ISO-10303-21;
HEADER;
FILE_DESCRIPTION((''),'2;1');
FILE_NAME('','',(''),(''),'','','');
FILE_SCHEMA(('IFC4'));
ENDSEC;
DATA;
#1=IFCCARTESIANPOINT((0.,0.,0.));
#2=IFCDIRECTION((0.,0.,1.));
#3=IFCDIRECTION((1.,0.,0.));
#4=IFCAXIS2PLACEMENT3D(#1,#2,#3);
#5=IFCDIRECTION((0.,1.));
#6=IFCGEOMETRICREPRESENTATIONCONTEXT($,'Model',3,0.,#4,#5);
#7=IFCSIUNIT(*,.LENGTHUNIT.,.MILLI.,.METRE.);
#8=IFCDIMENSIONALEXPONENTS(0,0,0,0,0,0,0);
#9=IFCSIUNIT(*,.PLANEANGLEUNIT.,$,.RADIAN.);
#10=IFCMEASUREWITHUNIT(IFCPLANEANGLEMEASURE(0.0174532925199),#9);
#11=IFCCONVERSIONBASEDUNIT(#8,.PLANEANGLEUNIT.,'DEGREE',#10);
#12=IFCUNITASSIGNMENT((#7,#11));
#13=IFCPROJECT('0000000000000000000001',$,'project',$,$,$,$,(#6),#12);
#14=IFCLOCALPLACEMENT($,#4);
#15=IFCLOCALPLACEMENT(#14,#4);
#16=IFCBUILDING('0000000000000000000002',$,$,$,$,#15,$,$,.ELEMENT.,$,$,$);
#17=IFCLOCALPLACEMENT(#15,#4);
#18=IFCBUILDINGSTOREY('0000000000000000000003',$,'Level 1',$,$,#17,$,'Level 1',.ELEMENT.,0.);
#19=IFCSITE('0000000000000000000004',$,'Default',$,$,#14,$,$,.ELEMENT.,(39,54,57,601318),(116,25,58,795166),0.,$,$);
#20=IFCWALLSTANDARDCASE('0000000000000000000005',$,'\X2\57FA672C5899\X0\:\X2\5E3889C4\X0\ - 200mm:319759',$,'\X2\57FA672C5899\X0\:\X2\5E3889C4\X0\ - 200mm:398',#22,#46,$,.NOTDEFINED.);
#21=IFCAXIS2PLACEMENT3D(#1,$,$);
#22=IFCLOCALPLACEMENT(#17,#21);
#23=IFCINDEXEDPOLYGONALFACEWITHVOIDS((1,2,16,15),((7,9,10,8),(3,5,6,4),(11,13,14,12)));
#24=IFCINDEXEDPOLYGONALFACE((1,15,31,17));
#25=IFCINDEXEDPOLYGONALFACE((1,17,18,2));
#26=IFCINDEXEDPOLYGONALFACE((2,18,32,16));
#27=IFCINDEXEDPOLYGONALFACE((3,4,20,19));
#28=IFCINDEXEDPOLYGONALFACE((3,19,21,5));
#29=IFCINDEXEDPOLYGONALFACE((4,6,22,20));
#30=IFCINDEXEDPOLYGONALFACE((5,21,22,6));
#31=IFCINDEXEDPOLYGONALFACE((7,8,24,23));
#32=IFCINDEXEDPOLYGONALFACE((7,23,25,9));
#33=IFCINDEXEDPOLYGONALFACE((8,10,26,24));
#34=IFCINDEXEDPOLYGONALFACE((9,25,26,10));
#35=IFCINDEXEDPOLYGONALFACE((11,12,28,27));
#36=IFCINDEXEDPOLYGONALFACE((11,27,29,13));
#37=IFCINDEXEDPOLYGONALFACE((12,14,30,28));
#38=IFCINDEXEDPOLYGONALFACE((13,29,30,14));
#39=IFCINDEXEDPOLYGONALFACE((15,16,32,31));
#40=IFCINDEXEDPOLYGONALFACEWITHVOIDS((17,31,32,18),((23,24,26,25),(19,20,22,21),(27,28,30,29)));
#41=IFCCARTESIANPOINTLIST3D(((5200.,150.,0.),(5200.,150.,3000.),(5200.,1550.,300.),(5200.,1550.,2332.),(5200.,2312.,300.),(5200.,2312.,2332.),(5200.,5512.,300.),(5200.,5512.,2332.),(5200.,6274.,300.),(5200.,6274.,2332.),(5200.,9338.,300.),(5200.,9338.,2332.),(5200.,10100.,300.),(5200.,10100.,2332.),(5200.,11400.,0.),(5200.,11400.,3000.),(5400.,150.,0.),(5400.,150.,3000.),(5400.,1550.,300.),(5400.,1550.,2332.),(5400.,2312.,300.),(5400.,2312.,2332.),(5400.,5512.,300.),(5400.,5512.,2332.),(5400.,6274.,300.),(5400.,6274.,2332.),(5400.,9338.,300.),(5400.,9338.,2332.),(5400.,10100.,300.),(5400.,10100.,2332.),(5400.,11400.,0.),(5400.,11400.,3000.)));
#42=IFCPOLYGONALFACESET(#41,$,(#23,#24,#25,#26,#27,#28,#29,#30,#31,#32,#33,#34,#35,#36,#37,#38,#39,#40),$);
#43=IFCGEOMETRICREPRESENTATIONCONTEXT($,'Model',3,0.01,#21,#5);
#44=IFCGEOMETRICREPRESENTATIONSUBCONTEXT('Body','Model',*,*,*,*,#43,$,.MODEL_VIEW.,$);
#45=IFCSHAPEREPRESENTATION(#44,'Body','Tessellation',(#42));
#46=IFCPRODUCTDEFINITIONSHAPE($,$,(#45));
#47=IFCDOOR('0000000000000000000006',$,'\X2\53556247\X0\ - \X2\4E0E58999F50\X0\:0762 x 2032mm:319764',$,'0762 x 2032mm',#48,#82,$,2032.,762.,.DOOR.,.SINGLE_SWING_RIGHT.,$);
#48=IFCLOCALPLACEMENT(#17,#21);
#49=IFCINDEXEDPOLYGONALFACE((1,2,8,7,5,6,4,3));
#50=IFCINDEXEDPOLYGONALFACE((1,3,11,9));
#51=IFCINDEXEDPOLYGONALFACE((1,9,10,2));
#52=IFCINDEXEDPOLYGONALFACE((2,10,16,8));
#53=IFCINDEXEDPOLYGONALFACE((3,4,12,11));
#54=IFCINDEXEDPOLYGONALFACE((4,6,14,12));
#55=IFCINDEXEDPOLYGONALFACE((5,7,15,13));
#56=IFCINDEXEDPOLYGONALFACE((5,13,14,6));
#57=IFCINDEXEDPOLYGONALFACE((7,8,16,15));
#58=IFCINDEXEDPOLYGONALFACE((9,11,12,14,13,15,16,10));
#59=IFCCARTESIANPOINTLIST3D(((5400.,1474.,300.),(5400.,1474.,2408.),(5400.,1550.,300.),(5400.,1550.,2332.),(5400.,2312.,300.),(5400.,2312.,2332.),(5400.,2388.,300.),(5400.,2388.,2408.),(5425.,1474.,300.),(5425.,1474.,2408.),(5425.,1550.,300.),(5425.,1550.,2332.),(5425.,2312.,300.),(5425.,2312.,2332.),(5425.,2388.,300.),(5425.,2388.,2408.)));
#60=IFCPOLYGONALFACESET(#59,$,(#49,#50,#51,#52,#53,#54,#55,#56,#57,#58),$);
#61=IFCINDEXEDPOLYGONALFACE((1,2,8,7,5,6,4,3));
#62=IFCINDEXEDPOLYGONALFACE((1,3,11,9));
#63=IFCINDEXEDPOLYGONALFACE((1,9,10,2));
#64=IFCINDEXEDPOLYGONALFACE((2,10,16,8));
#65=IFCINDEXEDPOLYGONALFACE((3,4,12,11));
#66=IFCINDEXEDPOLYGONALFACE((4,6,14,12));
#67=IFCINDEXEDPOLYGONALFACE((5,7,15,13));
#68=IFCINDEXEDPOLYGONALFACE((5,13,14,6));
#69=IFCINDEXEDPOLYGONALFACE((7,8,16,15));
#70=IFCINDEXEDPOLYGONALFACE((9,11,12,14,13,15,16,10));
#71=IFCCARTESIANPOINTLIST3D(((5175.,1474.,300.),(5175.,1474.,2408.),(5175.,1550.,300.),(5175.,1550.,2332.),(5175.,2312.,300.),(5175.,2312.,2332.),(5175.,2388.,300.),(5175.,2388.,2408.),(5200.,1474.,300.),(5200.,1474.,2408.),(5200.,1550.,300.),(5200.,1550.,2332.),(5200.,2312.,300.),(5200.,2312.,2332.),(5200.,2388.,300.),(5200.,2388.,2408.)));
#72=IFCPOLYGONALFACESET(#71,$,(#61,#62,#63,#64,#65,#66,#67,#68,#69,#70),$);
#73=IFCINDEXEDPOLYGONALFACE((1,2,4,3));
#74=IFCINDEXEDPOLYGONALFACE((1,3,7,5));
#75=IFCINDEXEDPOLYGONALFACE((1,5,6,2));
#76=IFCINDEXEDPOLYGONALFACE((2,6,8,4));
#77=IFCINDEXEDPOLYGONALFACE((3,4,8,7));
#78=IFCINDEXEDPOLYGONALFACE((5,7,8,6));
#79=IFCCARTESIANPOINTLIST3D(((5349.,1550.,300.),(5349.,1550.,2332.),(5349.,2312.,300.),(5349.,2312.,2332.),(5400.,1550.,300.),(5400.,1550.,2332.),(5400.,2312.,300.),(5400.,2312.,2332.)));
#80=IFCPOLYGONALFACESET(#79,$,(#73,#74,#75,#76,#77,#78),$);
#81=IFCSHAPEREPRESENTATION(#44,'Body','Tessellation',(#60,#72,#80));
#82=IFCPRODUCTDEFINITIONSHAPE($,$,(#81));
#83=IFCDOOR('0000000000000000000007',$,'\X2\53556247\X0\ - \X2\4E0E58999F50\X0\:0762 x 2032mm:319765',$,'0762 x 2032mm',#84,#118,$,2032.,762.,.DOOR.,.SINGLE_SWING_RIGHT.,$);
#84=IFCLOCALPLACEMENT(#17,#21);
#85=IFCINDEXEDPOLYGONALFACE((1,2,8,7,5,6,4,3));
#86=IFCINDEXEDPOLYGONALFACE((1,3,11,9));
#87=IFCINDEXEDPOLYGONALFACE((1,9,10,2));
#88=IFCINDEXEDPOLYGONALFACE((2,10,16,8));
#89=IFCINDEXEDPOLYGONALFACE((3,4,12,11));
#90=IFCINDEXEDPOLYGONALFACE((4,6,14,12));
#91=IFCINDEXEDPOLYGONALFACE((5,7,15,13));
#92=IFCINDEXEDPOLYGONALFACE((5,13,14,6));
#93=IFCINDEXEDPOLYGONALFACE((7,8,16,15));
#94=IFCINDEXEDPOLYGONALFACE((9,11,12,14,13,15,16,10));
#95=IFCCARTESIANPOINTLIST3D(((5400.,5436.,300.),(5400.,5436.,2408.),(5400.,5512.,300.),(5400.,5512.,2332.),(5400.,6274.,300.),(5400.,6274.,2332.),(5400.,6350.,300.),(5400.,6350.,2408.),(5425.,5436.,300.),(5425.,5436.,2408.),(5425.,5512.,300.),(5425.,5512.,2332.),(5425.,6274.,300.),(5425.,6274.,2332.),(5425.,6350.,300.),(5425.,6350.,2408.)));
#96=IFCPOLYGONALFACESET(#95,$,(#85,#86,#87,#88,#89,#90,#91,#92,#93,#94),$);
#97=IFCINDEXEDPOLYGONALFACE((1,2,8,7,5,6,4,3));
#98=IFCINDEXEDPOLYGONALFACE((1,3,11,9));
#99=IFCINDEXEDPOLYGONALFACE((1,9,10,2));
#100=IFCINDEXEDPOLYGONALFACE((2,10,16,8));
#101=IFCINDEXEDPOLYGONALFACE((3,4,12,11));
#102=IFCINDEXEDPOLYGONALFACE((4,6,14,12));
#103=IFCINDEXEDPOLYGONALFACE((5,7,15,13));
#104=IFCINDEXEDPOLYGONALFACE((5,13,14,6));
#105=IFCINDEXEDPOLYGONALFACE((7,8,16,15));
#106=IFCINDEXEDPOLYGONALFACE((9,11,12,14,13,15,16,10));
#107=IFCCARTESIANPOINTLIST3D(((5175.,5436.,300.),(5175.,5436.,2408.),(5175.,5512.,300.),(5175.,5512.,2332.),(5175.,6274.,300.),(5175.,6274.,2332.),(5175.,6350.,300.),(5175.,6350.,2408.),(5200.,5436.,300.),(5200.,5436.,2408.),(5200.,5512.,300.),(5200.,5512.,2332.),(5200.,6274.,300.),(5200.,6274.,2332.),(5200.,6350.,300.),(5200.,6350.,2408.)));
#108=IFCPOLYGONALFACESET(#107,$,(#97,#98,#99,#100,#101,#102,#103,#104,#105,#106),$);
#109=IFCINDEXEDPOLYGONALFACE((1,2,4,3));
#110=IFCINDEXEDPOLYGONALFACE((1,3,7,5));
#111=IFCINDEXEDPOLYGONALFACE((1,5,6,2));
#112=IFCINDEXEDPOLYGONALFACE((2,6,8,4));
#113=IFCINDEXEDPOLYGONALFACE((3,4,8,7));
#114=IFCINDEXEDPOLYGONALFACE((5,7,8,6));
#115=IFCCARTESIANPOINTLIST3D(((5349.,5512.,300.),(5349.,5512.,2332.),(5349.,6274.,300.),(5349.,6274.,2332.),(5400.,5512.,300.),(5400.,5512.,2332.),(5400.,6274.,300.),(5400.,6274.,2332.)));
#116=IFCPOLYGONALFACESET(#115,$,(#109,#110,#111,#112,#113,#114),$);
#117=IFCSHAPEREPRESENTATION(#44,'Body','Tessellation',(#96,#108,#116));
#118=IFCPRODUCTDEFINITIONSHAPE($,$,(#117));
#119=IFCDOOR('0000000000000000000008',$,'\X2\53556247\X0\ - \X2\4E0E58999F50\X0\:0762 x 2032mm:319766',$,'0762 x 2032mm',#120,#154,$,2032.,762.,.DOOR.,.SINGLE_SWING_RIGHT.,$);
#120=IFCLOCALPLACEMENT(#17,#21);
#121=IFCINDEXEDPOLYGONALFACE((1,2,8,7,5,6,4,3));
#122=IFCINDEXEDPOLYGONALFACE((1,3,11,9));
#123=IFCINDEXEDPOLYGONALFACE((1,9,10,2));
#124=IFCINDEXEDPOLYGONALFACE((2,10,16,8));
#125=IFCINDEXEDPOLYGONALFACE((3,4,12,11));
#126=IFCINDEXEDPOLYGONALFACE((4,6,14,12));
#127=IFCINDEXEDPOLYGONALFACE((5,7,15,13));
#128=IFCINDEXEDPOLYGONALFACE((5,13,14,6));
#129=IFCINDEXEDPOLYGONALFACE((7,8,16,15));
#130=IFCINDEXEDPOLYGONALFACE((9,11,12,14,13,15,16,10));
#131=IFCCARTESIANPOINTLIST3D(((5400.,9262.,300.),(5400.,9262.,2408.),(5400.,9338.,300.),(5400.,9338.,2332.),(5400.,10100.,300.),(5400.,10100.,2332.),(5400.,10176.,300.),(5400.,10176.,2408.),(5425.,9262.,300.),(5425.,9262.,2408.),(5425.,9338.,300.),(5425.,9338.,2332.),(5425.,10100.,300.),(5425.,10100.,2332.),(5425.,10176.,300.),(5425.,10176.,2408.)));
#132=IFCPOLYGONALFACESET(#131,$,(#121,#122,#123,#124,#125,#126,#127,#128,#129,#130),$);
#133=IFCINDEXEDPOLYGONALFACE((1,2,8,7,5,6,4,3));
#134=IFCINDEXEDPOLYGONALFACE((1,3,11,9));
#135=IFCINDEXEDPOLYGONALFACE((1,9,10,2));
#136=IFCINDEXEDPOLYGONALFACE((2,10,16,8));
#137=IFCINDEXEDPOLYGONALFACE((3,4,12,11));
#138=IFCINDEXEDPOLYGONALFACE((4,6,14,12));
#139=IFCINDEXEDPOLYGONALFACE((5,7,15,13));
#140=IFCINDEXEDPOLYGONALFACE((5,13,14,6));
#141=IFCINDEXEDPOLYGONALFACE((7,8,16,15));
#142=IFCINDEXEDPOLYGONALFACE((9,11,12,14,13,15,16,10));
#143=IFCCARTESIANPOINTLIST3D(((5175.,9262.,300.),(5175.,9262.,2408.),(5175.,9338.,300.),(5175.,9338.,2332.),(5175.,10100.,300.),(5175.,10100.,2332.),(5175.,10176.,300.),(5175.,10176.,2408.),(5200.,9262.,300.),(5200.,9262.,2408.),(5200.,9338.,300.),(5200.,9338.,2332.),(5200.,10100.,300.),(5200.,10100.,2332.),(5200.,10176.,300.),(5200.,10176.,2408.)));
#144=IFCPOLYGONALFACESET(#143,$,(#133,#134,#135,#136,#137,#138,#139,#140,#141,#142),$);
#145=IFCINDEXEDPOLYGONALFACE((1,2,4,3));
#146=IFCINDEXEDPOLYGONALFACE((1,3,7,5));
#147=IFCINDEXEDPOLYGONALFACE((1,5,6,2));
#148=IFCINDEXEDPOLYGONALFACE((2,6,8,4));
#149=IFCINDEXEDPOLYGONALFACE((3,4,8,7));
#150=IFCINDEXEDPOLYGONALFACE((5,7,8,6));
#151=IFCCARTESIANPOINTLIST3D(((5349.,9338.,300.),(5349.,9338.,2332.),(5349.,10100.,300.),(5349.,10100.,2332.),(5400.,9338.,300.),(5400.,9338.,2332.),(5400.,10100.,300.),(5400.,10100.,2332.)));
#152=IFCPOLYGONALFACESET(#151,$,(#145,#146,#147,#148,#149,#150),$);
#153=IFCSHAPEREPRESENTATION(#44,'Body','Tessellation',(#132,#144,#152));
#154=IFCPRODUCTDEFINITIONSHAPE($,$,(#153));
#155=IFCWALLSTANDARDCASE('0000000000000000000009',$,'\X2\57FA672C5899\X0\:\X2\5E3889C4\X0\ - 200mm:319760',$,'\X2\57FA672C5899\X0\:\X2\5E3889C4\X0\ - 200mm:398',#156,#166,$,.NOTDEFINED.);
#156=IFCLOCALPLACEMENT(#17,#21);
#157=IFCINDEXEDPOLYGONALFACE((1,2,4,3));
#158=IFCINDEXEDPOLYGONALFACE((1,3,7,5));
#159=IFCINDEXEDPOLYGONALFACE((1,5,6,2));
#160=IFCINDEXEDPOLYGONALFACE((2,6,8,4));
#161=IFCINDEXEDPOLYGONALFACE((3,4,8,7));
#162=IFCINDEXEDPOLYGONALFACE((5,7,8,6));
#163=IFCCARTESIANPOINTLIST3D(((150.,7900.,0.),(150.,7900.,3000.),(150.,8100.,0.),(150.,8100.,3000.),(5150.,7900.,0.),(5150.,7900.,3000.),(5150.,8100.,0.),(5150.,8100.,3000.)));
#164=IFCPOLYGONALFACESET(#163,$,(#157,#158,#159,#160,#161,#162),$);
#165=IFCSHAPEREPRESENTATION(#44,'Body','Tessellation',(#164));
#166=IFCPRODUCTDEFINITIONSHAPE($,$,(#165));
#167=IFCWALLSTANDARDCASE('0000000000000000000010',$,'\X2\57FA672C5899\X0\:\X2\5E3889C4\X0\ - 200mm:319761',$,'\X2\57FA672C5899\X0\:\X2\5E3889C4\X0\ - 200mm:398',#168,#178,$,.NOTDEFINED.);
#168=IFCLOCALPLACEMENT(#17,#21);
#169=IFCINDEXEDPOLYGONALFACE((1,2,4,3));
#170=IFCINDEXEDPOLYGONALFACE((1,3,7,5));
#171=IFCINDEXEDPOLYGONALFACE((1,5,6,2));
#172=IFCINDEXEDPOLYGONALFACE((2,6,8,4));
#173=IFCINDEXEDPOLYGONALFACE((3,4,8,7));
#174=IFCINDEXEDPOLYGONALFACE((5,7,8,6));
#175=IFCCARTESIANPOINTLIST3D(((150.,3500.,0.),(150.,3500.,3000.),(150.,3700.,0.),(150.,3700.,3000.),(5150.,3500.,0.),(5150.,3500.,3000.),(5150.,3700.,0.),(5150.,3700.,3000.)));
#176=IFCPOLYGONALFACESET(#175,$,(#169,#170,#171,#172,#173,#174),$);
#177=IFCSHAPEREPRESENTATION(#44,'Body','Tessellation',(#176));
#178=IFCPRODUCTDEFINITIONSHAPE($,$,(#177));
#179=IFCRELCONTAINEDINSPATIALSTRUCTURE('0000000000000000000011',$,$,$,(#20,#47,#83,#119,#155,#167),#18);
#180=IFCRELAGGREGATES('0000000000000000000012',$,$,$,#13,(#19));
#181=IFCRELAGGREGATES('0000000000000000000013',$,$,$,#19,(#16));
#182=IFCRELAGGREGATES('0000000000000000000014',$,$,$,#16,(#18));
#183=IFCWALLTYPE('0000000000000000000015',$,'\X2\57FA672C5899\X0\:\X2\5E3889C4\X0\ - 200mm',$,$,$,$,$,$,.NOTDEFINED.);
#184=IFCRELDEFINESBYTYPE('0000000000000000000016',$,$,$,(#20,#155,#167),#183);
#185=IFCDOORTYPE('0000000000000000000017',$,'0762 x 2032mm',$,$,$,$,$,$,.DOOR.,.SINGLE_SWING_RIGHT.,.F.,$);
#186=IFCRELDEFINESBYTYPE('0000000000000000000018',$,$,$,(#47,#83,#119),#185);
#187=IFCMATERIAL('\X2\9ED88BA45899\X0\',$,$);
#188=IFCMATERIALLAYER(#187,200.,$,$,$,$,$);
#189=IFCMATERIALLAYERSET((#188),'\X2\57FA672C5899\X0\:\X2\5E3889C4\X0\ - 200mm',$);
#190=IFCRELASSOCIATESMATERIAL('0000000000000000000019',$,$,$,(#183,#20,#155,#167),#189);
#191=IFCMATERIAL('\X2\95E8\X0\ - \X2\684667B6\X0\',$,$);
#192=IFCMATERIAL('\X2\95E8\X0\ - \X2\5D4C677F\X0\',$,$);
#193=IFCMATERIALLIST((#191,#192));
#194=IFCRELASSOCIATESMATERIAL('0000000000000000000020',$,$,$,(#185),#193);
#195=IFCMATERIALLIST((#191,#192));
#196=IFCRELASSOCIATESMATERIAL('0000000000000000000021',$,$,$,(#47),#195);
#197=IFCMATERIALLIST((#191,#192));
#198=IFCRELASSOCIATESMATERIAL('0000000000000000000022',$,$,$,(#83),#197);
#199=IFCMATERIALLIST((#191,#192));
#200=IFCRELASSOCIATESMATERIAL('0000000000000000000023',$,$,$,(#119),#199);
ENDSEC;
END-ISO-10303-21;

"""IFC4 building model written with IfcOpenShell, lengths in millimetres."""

from ifc_helpers import new_model, entity, si_unit, converted_unit, direction, frame, frame_2d, origin, origin_with_axes, origin_2d_with_axis, place, context, subcontext, project, spatial, polyline, rectangle, outline, extrude, source, transform, mapped, material, material_list, layer, layer_set, layer_usage, type_object, type_shapes, element, fill, save


model = new_model("IFC4")

# Units and contexts
model_context_1 = context("Model", 3, precision=0.0, world=origin_with_axes(), true_north=direction((0.0, 1.0)))
model_context_2 = context("Model", 3, precision=0.01, world=origin(), true_north=direction((0.0, 1.0)))
body_context_1 = subcontext(model_context_2, "Body", "Model", "MODEL_VIEW")
ifc_project = project(units=[si_unit("LENGTHUNIT", "METRE", prefix="MILLI"), converted_unit("PLANEANGLEUNIT", "DEGREE", entity("IfcPlaneAngleMeasure", 0.0174532925199), si_unit("PLANEANGLEUNIT", "RADIAN"), dimensions=[0, 0, 0, 0, 0, 0, 0])], contexts=[model_context_1])

# Site, building, storey
site_placement = place(None, origin_with_axes())
site = spatial("IfcSite", under=ifc_project, at=site_placement, Name="Default", CompositionType="ELEMENT", RefLatitude=(39, 54, 57, 601318), RefLongitude=(116, 25, 58, 795166), RefElevation=0.0)
building_placement = place(site_placement, origin_with_axes())
building = spatial("IfcBuilding", under=site, at=building_placement, CompositionType="ELEMENT")
storey_placement = place(building_placement, origin_with_axes())
storey = spatial("IfcBuildingStorey", under=building, at=storey_placement, Name="Level 1", LongName="Level 1", CompositionType="ELEMENT", Elevation=0.0)

# Shared definitions
placement_1 = place(None, origin())
placement_2 = place(placement_1, origin())
placement_3 = place(placement_2, origin())

# Wall, openings, doors
ifc_material_1 = material(Name="默认墙")
ifc_layer_1 = layer(ifc_material_1, 200.0)
ifc_layer_set_1 = layer_set([ifc_layer_1], Name="基本墙:常规 - 200mm")
ifc_layer_usage_1 = layer_usage(ifc_layer_set_1, "AXIS2", "NEGATIVE", 100.0)
wall_type_1 = type_object("IfcWallType", Name="基本墙:常规 - 200mm", PredefinedType="NOTDEFINED", material=ifc_layer_set_1)
wall_1_placement = place(placement_3, frame((5300.0, 11400.0, 0.0), z_axis=(0.0, 0.0, 1.0), x_axis=(0.0, -1.0, 0.0)))
wall_1 = element("IfcWallStandardCase", 1, at=wall_1_placement, inside=storey, type_object=wall_type_1, material=ifc_layer_usage_1, Name="基本墙:常规 - 200mm:319759", ObjectType="基本墙:常规 - 200mm:398", PredefinedType="NOTDEFINED", context=body_context_1, shape_type="SweptSolid", body=[
    extrude(rectangle(XDim=11250.0, YDim=200.0, at=frame_2d((5625.0, 0.0), x_axis=(-1.0, 0.0))), origin(), (0.0, 0.0, 1.0), 3000.0),
])
opening_1_placement = place(wall_1_placement, frame((9088.0, -100.0, 300.0)))
opening_1 = element("IfcOpeningElement", 2, at=opening_1_placement, cuts=wall_1, ObjectType="Opening", PredefinedType="OPENING", context=body_context_1, shape_type="SweptSolid", body=[
    extrude(rectangle(XDim=762.0, YDim=2032.0, at=frame_2d((1016.0, 381.0), x_axis=(0.0, 1.0))), frame((0.0, 0.0, 0.0), z_axis=(0.0, 1.0, 0.0), x_axis=(0.0, 0.0, 1.0)), (0.0, 0.0, 1.0), 200.0),
])
opening_2_placement = place(wall_1_placement, frame((5126.0, -100.0, 300.0)))
opening_2 = element("IfcOpeningElement", 3, at=opening_2_placement, cuts=wall_1, ObjectType="Opening", PredefinedType="OPENING", context=body_context_1, shape_type="SweptSolid", body=[
    extrude(rectangle(XDim=762.0, YDim=2032.0, at=frame_2d((1016.0, 381.0), x_axis=(0.0, 1.0))), frame((0.0, 0.0, 0.0), z_axis=(0.0, 1.0, 0.0), x_axis=(0.0, 0.0, 1.0)), (0.0, 0.0, 1.0), 200.0),
])
opening_3_placement = place(wall_1_placement, frame((1300.0, -100.0, 300.0)))
opening_3 = element("IfcOpeningElement", 4, at=opening_3_placement, cuts=wall_1, ObjectType="Opening", PredefinedType="OPENING", context=body_context_1, shape_type="SweptSolid", body=[
    extrude(rectangle(XDim=762.0, YDim=2032.0, at=frame_2d((1016.0, 381.0), x_axis=(0.0, 1.0))), frame((0.0, 0.0, 0.0), z_axis=(0.0, 1.0, 0.0), x_axis=(0.0, 0.0, 1.0)), (0.0, 0.0, 1.0), 200.0),
])
ifc_material_2 = material(Name="门 - 框架")
ifc_material_3 = material(Name="门 - 嵌板")
ifc_material_list_1 = material_list([ifc_material_2, ifc_material_3])
ifc_material_list_2 = material_list([ifc_material_2, ifc_material_3])
door_type_1 = type_object("IfcDoorType", Name="0762 x 2032mm", OperationType="SINGLE_SWING_RIGHT", ParameterTakesPrecedence=False, PredefinedType="DOOR", material=ifc_material_list_2)
shared_shape_1 = source(origin(), body_context_1, "Body", "SweptSolid", [
    extrude(outline(polyline([(-457.0, -1073.0), (457.0, -1073.0), (457.0, 1035.0), (381.0, 1035.0), (381.0, -997.0), (-381.0, -997.0), (-381.0, 1035.0), (-457.0, 1035.0), (-457.0, -1073.0)])), frame((381.0, 200.0, 1035.0), z_axis=(0.0, 1.0, 0.0), x_axis=(1.0, 0.0, 0.0)), (0.0, 0.0, 1.0), 25.0),
    extrude(outline(polyline([(-1073.0, -457.0), (1035.0, -457.0), (1035.0, -381.0), (-997.0, -381.0), (-997.0, 381.0), (1035.0, 381.0), (1035.0, 457.0), (-1073.0, 457.0), (-1073.0, -457.0)])), frame((381.0, -25.0, 1035.0), z_axis=(0.0, 1.0, 0.0), x_axis=(0.0, 0.0, -1.0)), (0.0, 0.0, 1.0), 25.0),
    extrude(rectangle(XDim=51.0, YDim=762.0, at=origin_2d_with_axis()), frame((381.0, 174.5, 0.0), z_axis=(0.0, 0.0, 1.0), x_axis=(0.0, 1.0, 0.0)), (0.0, 0.0, 1.0), 2032.0),
])
type_shapes(door_type_1, [shared_shape_1])
door_1_placement = place(opening_1_placement, origin())
door_1 = element("IfcDoor", 5, at=door_1_placement, inside=storey, type_object=door_type_1, material=ifc_material_list_1, Name="单扇 - 与墙齐:0762 x 2032mm:319764", ObjectType="0762 x 2032mm", OperationType="SINGLE_SWING_RIGHT", OverallHeight=2032.0, OverallWidth=762.0, PredefinedType="DOOR", context=body_context_1, shape_type="MappedRepresentation", body=[
    mapped(shared_shape_1, transform((0.0, 0.0, 0.0), scale=1.0)),
])
fill(opening_1, door_1)
ifc_material_list_3 = material_list([ifc_material_2, ifc_material_3])
door_2_placement = place(opening_2_placement, origin())
door_2 = element("IfcDoor", 6, at=door_2_placement, inside=storey, type_object=door_type_1, material=ifc_material_list_3, Name="单扇 - 与墙齐:0762 x 2032mm:319765", ObjectType="0762 x 2032mm", OperationType="SINGLE_SWING_RIGHT", OverallHeight=2032.0, OverallWidth=762.0, PredefinedType="DOOR", context=body_context_1, shape_type="MappedRepresentation", body=[
    mapped(shared_shape_1, transform((0.0, 0.0, 0.0), scale=1.0)),
])
fill(opening_2, door_2)
ifc_material_list_4 = material_list([ifc_material_2, ifc_material_3])
door_3_placement = place(opening_3_placement, origin())
door_3 = element("IfcDoor", 7, at=door_3_placement, inside=storey, type_object=door_type_1, material=ifc_material_list_4, Name="单扇 - 与墙齐:0762 x 2032mm:319766", ObjectType="0762 x 2032mm", OperationType="SINGLE_SWING_RIGHT", OverallHeight=2032.0, OverallWidth=762.0, PredefinedType="DOOR", context=body_context_1, shape_type="MappedRepresentation", body=[
    mapped(shared_shape_1, transform((0.0, 0.0, 0.0), scale=1.0)),
])
fill(opening_3, door_3)

# Walls
ifc_layer_usage_2 = layer_usage(ifc_layer_set_1, "AXIS2", "NEGATIVE", 100.0)
wall_2_placement = place(placement_3, frame((150.0, 8000.0, 0.0)))
element("IfcWallStandardCase", 8, at=wall_2_placement, inside=storey, type_object=wall_type_1, material=ifc_layer_usage_2, Name="基本墙:常规 - 200mm:319760", ObjectType="基本墙:常规 - 200mm:398", PredefinedType="NOTDEFINED", context=body_context_1, shape_type="SweptSolid", body=[
    extrude(rectangle(XDim=5000.0, YDim=200.0, at=frame_2d((2500.0, 0.0), x_axis=(-1.0, 0.0))), origin(), (0.0, 0.0, 1.0), 3000.0),
])
ifc_layer_usage_3 = layer_usage(ifc_layer_set_1, "AXIS2", "NEGATIVE", 100.0)
wall_3_placement = place(placement_3, frame((150.0, 3600.0, 0.0)))
element("IfcWallStandardCase", 9, at=wall_3_placement, inside=storey, type_object=wall_type_1, material=ifc_layer_usage_3, Name="基本墙:常规 - 200mm:319761", ObjectType="基本墙:常规 - 200mm:398", PredefinedType="NOTDEFINED", context=body_context_1, shape_type="SweptSolid", body=[
    extrude(rectangle(XDim=5000.0, YDim=200.0, at=frame_2d((2500.0, 0.0), x_axis=(-1.0, 0.0))), origin(), (0.0, 0.0, 1.0), 3000.0),
])

save(model, "model.ifc")
